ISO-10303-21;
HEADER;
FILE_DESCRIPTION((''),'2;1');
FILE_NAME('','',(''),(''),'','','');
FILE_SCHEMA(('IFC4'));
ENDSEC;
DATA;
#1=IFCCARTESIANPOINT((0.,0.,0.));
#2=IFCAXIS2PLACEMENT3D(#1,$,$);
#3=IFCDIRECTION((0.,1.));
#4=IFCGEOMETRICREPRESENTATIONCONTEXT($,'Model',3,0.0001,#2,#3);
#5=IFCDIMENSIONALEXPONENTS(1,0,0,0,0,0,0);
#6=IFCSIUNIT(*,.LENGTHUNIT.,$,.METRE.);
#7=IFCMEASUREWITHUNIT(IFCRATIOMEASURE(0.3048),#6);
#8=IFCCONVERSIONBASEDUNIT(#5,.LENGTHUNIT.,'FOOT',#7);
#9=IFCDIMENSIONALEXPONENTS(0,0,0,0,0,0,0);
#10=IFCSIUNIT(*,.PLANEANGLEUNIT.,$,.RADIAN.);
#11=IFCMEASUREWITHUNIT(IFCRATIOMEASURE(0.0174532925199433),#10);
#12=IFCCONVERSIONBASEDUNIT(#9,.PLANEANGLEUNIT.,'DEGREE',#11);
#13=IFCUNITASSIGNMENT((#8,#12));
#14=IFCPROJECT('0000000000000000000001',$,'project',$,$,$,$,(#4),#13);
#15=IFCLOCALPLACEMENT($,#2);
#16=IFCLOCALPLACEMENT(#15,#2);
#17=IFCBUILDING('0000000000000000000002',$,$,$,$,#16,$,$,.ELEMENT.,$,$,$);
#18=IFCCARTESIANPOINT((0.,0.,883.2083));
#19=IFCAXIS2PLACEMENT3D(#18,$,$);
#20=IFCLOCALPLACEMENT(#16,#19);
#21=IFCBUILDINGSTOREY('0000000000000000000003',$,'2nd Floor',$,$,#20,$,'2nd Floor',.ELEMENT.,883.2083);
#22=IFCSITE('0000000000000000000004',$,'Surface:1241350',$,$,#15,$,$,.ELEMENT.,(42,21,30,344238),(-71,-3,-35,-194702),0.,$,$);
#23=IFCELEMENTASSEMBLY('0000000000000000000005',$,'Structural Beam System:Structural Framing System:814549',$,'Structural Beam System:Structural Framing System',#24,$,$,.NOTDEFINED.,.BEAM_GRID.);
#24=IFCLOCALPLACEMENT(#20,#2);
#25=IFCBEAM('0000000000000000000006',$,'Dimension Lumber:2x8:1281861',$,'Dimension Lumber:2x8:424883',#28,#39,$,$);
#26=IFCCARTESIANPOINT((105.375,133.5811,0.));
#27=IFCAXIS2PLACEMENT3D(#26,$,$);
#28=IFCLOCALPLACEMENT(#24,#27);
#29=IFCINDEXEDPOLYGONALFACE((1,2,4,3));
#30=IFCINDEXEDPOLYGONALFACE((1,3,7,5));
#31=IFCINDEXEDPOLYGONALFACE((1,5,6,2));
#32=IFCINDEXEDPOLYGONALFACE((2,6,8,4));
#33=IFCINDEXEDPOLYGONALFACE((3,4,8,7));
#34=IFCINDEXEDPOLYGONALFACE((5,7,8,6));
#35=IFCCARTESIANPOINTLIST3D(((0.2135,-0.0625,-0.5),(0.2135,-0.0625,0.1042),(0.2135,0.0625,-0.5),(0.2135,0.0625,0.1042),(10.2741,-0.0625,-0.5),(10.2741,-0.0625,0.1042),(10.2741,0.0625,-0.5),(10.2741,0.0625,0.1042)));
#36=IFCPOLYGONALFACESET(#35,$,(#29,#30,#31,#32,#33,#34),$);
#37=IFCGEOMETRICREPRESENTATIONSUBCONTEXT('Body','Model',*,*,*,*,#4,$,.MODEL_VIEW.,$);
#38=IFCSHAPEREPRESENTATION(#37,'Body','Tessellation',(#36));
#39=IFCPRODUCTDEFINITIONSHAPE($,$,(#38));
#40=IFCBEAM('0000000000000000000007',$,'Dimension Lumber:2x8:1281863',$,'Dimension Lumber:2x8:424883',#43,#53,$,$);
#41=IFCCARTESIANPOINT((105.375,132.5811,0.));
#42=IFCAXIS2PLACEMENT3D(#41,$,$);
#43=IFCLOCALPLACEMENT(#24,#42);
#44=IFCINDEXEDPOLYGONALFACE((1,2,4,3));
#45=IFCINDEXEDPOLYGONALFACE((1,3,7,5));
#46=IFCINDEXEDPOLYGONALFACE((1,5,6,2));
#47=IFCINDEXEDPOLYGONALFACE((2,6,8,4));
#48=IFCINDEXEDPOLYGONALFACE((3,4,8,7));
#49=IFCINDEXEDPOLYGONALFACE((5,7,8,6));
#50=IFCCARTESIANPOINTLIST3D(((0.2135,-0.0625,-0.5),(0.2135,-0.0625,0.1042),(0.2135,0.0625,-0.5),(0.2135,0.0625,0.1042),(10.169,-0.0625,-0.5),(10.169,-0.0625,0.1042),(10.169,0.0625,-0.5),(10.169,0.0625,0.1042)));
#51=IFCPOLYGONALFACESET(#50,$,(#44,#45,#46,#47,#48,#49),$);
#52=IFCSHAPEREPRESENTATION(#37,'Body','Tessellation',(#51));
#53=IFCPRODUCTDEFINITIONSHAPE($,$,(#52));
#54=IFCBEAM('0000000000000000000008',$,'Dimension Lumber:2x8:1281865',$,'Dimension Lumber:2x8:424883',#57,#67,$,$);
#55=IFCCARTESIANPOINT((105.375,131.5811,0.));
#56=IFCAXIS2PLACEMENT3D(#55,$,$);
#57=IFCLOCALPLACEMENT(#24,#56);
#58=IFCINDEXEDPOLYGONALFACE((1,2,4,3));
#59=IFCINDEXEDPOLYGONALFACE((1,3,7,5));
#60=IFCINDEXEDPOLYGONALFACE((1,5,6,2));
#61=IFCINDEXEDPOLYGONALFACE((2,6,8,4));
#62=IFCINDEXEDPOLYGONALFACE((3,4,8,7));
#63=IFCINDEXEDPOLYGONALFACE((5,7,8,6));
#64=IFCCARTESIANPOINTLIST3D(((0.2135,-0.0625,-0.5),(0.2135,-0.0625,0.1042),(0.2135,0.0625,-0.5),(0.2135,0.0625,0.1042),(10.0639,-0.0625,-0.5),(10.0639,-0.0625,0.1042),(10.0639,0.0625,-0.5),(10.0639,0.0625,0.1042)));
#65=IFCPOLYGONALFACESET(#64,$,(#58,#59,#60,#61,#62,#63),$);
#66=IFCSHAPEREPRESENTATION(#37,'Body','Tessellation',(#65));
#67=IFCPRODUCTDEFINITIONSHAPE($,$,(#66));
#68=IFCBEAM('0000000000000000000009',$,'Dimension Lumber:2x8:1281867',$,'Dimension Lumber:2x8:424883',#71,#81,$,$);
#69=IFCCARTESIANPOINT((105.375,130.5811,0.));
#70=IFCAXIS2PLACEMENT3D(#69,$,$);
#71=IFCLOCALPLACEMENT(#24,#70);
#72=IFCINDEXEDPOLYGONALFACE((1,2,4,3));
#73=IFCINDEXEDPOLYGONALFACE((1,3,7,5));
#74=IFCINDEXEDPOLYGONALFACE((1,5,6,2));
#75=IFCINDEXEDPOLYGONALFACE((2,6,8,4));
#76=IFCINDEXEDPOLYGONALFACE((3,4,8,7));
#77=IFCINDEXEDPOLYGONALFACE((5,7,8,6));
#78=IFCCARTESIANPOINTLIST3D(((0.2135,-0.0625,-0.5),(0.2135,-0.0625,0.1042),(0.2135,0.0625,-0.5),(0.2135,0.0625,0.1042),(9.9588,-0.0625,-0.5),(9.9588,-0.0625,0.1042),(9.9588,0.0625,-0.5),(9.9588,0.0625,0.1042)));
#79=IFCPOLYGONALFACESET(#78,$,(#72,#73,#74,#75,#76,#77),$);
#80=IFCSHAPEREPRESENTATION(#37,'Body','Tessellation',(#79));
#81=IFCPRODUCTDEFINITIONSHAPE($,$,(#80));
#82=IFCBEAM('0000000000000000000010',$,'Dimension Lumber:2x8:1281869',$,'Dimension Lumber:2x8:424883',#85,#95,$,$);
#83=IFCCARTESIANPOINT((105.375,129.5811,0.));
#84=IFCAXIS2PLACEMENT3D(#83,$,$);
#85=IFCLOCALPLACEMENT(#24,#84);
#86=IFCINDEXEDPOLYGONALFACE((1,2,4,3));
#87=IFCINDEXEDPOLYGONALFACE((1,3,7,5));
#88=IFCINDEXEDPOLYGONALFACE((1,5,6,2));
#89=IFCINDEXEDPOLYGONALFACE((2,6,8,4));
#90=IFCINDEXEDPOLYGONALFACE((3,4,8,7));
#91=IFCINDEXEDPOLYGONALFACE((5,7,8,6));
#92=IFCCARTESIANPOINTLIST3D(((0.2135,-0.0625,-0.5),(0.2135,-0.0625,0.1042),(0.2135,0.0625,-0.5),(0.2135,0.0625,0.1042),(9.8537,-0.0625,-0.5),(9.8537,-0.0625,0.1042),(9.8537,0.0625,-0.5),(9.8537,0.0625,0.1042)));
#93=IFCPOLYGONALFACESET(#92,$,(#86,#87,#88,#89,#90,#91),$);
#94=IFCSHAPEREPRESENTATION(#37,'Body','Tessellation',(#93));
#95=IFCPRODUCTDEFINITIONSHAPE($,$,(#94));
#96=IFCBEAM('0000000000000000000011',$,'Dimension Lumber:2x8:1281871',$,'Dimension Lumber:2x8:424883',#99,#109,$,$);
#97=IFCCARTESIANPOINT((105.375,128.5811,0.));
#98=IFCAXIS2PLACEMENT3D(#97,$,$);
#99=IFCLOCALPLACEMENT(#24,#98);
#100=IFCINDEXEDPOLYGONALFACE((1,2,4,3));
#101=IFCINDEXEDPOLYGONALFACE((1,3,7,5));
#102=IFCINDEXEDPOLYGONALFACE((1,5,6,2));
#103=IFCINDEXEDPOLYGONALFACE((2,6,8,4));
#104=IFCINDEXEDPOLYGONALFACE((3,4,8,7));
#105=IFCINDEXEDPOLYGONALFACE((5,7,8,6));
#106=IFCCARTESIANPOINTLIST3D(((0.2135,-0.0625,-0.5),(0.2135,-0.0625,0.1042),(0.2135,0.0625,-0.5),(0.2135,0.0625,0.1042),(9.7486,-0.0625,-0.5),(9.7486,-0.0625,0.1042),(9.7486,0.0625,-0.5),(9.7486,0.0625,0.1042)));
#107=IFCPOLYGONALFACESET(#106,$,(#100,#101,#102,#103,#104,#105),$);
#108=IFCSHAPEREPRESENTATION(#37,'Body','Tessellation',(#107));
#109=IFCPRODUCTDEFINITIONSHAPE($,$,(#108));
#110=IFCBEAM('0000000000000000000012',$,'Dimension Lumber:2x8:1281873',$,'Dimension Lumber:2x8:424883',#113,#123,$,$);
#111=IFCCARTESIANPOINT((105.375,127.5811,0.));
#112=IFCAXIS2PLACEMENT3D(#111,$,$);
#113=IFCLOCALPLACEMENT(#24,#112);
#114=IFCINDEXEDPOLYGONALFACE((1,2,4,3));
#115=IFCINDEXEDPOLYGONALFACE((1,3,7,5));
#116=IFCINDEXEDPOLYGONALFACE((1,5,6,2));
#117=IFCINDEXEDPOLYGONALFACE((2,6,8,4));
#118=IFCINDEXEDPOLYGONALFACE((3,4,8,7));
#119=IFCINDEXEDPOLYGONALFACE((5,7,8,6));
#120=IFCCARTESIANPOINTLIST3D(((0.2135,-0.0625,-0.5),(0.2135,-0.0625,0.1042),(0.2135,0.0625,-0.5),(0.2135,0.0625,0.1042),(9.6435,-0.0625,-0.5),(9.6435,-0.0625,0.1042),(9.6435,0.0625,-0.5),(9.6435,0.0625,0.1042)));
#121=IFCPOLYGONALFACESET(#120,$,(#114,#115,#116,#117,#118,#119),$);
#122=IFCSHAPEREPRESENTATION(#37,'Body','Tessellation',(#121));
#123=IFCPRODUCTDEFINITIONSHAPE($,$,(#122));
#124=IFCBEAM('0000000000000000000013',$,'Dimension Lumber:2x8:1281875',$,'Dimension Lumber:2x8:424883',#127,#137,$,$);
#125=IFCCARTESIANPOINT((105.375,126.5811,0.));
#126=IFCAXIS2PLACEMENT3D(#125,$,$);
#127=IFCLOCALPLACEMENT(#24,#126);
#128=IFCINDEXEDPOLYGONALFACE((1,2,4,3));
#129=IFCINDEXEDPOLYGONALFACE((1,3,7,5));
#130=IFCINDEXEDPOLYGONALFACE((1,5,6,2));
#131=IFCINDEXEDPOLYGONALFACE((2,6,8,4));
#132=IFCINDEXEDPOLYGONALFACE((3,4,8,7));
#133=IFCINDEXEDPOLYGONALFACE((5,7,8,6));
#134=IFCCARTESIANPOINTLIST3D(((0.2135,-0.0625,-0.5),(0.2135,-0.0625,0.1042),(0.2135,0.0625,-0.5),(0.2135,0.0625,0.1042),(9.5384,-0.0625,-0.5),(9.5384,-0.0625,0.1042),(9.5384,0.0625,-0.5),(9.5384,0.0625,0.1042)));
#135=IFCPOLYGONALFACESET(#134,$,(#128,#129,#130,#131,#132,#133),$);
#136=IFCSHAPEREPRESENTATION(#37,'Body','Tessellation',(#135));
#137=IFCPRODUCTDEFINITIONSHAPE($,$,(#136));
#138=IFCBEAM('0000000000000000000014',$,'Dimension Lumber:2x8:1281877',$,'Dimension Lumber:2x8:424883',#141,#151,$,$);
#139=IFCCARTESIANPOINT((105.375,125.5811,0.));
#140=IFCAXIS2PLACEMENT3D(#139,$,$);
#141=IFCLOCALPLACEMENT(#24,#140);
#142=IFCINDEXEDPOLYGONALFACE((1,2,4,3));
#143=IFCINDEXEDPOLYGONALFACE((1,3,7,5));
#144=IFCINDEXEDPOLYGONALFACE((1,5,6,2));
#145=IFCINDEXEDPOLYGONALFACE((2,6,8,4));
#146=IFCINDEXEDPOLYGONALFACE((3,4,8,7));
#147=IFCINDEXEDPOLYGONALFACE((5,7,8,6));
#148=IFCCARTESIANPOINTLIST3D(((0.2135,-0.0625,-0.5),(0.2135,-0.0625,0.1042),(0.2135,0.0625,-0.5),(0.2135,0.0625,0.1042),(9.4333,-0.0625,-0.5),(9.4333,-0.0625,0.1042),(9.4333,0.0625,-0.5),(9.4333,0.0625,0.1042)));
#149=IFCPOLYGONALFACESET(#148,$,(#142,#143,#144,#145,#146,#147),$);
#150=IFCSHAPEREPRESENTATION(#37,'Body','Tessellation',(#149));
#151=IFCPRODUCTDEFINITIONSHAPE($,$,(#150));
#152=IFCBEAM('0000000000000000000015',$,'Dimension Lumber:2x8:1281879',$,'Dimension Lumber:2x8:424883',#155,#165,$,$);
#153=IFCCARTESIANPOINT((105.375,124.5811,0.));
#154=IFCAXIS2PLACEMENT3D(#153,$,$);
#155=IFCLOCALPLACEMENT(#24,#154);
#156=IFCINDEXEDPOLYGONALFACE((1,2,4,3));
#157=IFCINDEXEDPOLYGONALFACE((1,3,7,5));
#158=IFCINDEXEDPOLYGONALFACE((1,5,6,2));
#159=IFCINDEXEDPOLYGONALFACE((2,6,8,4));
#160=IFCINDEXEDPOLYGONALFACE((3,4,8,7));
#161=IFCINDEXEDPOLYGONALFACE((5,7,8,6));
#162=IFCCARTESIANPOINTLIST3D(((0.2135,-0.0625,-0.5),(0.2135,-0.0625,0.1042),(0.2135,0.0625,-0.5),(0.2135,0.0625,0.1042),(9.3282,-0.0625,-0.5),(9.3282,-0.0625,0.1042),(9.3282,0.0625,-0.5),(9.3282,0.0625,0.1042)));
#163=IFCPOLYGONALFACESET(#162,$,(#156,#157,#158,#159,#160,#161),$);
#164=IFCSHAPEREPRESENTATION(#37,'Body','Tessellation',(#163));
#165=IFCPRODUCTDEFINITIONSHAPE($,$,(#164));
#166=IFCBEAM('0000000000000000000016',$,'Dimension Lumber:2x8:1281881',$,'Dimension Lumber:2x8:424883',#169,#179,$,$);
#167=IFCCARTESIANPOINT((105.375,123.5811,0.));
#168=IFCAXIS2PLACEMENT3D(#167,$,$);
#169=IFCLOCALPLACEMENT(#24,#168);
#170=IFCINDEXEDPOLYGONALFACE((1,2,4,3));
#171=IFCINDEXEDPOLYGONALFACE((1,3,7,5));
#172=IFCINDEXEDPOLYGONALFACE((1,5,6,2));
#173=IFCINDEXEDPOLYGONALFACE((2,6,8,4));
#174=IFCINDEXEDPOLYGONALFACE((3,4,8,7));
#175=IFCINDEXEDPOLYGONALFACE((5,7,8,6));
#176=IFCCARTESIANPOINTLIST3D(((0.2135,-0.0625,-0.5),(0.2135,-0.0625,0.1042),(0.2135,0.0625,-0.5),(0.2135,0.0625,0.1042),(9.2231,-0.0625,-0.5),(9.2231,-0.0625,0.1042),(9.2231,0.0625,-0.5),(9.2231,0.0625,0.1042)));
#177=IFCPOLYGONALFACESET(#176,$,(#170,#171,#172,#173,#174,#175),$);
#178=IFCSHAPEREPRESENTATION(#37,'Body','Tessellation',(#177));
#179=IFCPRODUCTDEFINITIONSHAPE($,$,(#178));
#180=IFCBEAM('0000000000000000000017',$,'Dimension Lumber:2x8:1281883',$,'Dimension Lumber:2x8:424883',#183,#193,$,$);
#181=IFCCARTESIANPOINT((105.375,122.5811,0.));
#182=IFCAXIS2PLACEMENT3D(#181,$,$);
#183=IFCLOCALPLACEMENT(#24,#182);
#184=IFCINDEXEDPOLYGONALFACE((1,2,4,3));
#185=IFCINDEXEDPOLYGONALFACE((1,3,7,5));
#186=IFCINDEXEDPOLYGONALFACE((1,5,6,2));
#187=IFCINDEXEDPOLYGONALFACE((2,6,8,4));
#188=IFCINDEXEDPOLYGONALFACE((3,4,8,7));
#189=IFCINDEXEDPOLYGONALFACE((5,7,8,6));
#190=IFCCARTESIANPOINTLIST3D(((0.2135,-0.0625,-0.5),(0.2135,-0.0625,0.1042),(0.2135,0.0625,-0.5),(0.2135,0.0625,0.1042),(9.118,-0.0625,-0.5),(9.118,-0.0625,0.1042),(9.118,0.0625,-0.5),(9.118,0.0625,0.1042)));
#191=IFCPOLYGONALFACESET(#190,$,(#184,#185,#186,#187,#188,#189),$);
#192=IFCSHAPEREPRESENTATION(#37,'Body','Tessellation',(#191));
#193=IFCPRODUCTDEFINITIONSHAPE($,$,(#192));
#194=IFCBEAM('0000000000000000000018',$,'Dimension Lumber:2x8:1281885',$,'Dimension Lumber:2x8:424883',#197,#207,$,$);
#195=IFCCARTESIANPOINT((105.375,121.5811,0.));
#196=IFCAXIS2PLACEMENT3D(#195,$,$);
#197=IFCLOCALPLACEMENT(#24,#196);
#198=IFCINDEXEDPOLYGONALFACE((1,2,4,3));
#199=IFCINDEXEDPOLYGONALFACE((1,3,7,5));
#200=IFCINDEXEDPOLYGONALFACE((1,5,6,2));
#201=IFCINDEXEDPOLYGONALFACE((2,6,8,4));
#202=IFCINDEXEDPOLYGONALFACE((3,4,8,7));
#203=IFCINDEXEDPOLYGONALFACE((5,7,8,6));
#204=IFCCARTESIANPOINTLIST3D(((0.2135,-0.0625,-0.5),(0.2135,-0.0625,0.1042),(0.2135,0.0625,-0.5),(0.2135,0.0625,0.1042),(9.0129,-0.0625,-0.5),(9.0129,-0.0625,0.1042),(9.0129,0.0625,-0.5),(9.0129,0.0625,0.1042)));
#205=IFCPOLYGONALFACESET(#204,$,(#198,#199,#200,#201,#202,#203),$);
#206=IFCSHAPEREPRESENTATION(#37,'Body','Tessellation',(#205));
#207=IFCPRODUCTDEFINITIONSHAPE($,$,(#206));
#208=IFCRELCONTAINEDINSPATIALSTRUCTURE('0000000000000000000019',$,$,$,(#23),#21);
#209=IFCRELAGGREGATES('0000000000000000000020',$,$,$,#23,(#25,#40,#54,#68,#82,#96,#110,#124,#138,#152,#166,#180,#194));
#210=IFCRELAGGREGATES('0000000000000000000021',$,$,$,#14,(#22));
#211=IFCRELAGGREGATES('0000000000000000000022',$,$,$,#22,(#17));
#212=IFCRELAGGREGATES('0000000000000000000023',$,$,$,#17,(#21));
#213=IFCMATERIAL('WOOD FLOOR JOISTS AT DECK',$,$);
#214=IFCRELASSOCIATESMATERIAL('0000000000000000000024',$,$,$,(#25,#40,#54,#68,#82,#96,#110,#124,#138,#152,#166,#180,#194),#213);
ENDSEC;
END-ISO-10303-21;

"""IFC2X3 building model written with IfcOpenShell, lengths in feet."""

from ifc_helpers import new_model, entity, si_unit, converted_unit, direction, frame, frame_2d, origin, origin_2d_with_axis, place, context, subcontext, project, spatial, rectangle, extrude, material, element, aggregate, save


model = new_model("IFC2X3")

# Units and contexts
model_context = context("Model", 3, precision=0.0001, world=origin(), true_north=direction((0.0, 1.0)))
body_context = subcontext(model_context, "Body", "Model", "MODEL_VIEW")
ifc_project = project(units=[converted_unit("LENGTHUNIT", "FOOT", entity("IfcRatioMeasure", 0.3048), si_unit("LENGTHUNIT", "METRE"), dimensions=[1, 0, 0, 0, 0, 0, 0]), converted_unit("PLANEANGLEUNIT", "DEGREE", entity("IfcRatioMeasure", 0.0174532925199433), si_unit("PLANEANGLEUNIT", "RADIAN"), dimensions=[0, 0, 0, 0, 0, 0, 0])], contexts=[model_context])

# Site, building, storey
site_placement = place(None, origin())
site = spatial("IfcSite", under=ifc_project, at=site_placement, Name="Surface:1241350", CompositionType="ELEMENT", RefLatitude=(42, 21, 30, 344238), RefLongitude=(-71, -3, -35, -194702), RefElevation=0.0)
building_placement = place(site_placement, origin())
building = spatial("IfcBuilding", under=site, at=building_placement, CompositionType="ELEMENT")
storey_placement = place(building_placement, frame((0.0, 0.0, 883.2083)))
storey = spatial("IfcBuildingStorey", under=building, at=storey_placement, Name="2nd Floor", LongName="2nd Floor", CompositionType="ELEMENT", Elevation=883.2083)

# Element assembly, beams
assembly_placement = place(storey_placement, origin())
assembly = element("IfcElementAssembly", 1, at=assembly_placement, inside=storey, Name="Structural Beam System:Structural Framing System:814549", ObjectType="Structural Beam System:Structural Framing System", AssemblyPlace="NOTDEFINED", PredefinedType="BEAM_GRID")
ifc_material_1 = material(Name="WOOD FLOOR JOISTS AT DECK")
beam_1_placement = place(assembly_placement, frame((105.375, 133.5811, 0.0)))
beam_1 = element("IfcBeam", 2, at=beam_1_placement, material=ifc_material_1, Name="Dimension Lumber:2x8:1281861", ObjectType="Dimension Lumber:2x8:424883", context=body_context, shape_type="SweptSolid", body=[
    extrude(rectangle(XDim=0.6042, YDim=0.125, at=frame_2d((0.0, 0.0), x_axis=(1.0, 0.0))), frame((0.2135, 0.0, -0.1979), z_axis=(1.0, 0.0, 0.0), x_axis=(0.0, 0.0, -1.0)), (0.0, 0.0, 1.0), 10.0606),
])
beam_2_placement = place(assembly_placement, frame((105.375, 132.5811, 0.0)))
beam_2 = element("IfcBeam", 3, at=beam_2_placement, material=ifc_material_1, Name="Dimension Lumber:2x8:1281863", ObjectType="Dimension Lumber:2x8:424883", context=body_context, shape_type="SweptSolid", body=[
    extrude(rectangle(XDim=0.6042, YDim=0.125, at=origin_2d_with_axis()), frame((0.2135, 0.0, -0.1979), z_axis=(1.0, 0.0, 0.0), x_axis=(0.0, 0.0, -1.0)), (0.0, 0.0, 1.0), 9.9555),
])
beam_3_placement = place(assembly_placement, frame((105.375, 131.5811, 0.0)))
beam_3 = element("IfcBeam", 4, at=beam_3_placement, material=ifc_material_1, Name="Dimension Lumber:2x8:1281865", ObjectType="Dimension Lumber:2x8:424883", context=body_context, shape_type="SweptSolid", body=[
    extrude(rectangle(XDim=0.6042, YDim=0.125, at=origin_2d_with_axis()), frame((0.2135, 0.0, -0.1979), z_axis=(1.0, 0.0, 0.0), x_axis=(0.0, 0.0, -1.0)), (0.0, 0.0, 1.0), 9.8504),
])
beam_4_placement = place(assembly_placement, frame((105.375, 130.5811, 0.0)))
beam_4 = element("IfcBeam", 5, at=beam_4_placement, material=ifc_material_1, Name="Dimension Lumber:2x8:1281867", ObjectType="Dimension Lumber:2x8:424883", context=body_context, shape_type="SweptSolid", body=[
    extrude(rectangle(XDim=0.6042, YDim=0.125, at=origin_2d_with_axis()), frame((0.2135, 0.0, -0.1979), z_axis=(1.0, 0.0, 0.0), x_axis=(0.0, 0.0, -1.0)), (0.0, 0.0, 1.0), 9.7452),
])
beam_5_placement = place(assembly_placement, frame((105.375, 129.5811, 0.0)))
beam_5 = element("IfcBeam", 6, at=beam_5_placement, material=ifc_material_1, Name="Dimension Lumber:2x8:1281869", ObjectType="Dimension Lumber:2x8:424883", context=body_context, shape_type="SweptSolid", body=[
    extrude(rectangle(XDim=0.6042, YDim=0.125, at=origin_2d_with_axis()), frame((0.2135, 0.0, -0.1979), z_axis=(1.0, 0.0, 0.0), x_axis=(0.0, 0.0, -1.0)), (0.0, 0.0, 1.0), 9.6401),
])
beam_6_placement = place(assembly_placement, frame((105.375, 128.5811, 0.0)))
beam_6 = element("IfcBeam", 7, at=beam_6_placement, material=ifc_material_1, Name="Dimension Lumber:2x8:1281871", ObjectType="Dimension Lumber:2x8:424883", context=body_context, shape_type="SweptSolid", body=[
    extrude(rectangle(XDim=0.6042, YDim=0.125, at=origin_2d_with_axis()), frame((0.2135, 0.0, -0.1979), z_axis=(1.0, 0.0, 0.0), x_axis=(0.0, 0.0, -1.0)), (0.0, 0.0, 1.0), 9.535),
])
beam_7_placement = place(assembly_placement, frame((105.375, 127.5811, 0.0)))
beam_7 = element("IfcBeam", 8, at=beam_7_placement, material=ifc_material_1, Name="Dimension Lumber:2x8:1281873", ObjectType="Dimension Lumber:2x8:424883", context=body_context, shape_type="SweptSolid", body=[
    extrude(rectangle(XDim=0.6042, YDim=0.125, at=origin_2d_with_axis()), frame((0.2135, 0.0, -0.1979), z_axis=(1.0, 0.0, 0.0), x_axis=(0.0, 0.0, -1.0)), (0.0, 0.0, 1.0), 9.4299),
])
beam_8_placement = place(assembly_placement, frame((105.375, 126.5811, 0.0)))
beam_8 = element("IfcBeam", 9, at=beam_8_placement, material=ifc_material_1, Name="Dimension Lumber:2x8:1281875", ObjectType="Dimension Lumber:2x8:424883", context=body_context, shape_type="SweptSolid", body=[
    extrude(rectangle(XDim=0.6042, YDim=0.125, at=origin_2d_with_axis()), frame((0.2135, 0.0, -0.1979), z_axis=(1.0, 0.0, 0.0), x_axis=(0.0, 0.0, -1.0)), (0.0, 0.0, 1.0), 9.3248),
])
beam_9_placement = place(assembly_placement, frame((105.375, 125.5811, 0.0)))
beam_9 = element("IfcBeam", 10, at=beam_9_placement, material=ifc_material_1, Name="Dimension Lumber:2x8:1281877", ObjectType="Dimension Lumber:2x8:424883", context=body_context, shape_type="SweptSolid", body=[
    extrude(rectangle(XDim=0.6042, YDim=0.125, at=origin_2d_with_axis()), frame((0.2135, 0.0, -0.1979), z_axis=(1.0, 0.0, 0.0), x_axis=(0.0, 0.0, -1.0)), (0.0, 0.0, 1.0), 9.2197),
])
beam_10_placement = place(assembly_placement, frame((105.375, 124.5811, 0.0)))
beam_10 = element("IfcBeam", 11, at=beam_10_placement, material=ifc_material_1, Name="Dimension Lumber:2x8:1281879", ObjectType="Dimension Lumber:2x8:424883", context=body_context, shape_type="SweptSolid", body=[
    extrude(rectangle(XDim=0.6042, YDim=0.125, at=origin_2d_with_axis()), frame((0.2135, 0.0, -0.1979), z_axis=(1.0, 0.0, 0.0), x_axis=(0.0, 0.0, -1.0)), (0.0, 0.0, 1.0), 9.1146),
])
beam_11_placement = place(assembly_placement, frame((105.375, 123.5811, 0.0)))
beam_11 = element("IfcBeam", 12, at=beam_11_placement, material=ifc_material_1, Name="Dimension Lumber:2x8:1281881", ObjectType="Dimension Lumber:2x8:424883", context=body_context, shape_type="SweptSolid", body=[
    extrude(rectangle(XDim=0.6042, YDim=0.125, at=origin_2d_with_axis()), frame((0.2135, 0.0, -0.1979), z_axis=(1.0, 0.0, 0.0), x_axis=(0.0, 0.0, -1.0)), (0.0, 0.0, 1.0), 9.0095),
])
beam_12_placement = place(assembly_placement, frame((105.375, 122.5811, 0.0)))
beam_12 = element("IfcBeam", 13, at=beam_12_placement, material=ifc_material_1, Name="Dimension Lumber:2x8:1281883", ObjectType="Dimension Lumber:2x8:424883", context=body_context, shape_type="SweptSolid", body=[
    extrude(rectangle(XDim=0.6042, YDim=0.125, at=origin_2d_with_axis()), frame((0.2135, 0.0, -0.1979), z_axis=(1.0, 0.0, 0.0), x_axis=(0.0, 0.0, -1.0)), (0.0, 0.0, 1.0), 8.9044),
])
beam_13_placement = place(assembly_placement, frame((105.375, 121.5811, 0.0)))
beam_13 = element("IfcBeam", 14, at=beam_13_placement, material=ifc_material_1, Name="Dimension Lumber:2x8:1281885", ObjectType="Dimension Lumber:2x8:424883", context=body_context, shape_type="SweptSolid", body=[
    extrude(rectangle(XDim=0.6042, YDim=0.125, at=origin_2d_with_axis()), frame((0.2135, 0.0, -0.1979), z_axis=(1.0, 0.0, 0.0), x_axis=(0.0, 0.0, -1.0)), (0.0, 0.0, 1.0), 8.7993),
])
aggregate(assembly, [beam_1, beam_2, beam_3, beam_4, beam_5, beam_6, beam_7, beam_8, beam_9, beam_10, beam_11, beam_12, beam_13])

save(model, "model.ifc")
